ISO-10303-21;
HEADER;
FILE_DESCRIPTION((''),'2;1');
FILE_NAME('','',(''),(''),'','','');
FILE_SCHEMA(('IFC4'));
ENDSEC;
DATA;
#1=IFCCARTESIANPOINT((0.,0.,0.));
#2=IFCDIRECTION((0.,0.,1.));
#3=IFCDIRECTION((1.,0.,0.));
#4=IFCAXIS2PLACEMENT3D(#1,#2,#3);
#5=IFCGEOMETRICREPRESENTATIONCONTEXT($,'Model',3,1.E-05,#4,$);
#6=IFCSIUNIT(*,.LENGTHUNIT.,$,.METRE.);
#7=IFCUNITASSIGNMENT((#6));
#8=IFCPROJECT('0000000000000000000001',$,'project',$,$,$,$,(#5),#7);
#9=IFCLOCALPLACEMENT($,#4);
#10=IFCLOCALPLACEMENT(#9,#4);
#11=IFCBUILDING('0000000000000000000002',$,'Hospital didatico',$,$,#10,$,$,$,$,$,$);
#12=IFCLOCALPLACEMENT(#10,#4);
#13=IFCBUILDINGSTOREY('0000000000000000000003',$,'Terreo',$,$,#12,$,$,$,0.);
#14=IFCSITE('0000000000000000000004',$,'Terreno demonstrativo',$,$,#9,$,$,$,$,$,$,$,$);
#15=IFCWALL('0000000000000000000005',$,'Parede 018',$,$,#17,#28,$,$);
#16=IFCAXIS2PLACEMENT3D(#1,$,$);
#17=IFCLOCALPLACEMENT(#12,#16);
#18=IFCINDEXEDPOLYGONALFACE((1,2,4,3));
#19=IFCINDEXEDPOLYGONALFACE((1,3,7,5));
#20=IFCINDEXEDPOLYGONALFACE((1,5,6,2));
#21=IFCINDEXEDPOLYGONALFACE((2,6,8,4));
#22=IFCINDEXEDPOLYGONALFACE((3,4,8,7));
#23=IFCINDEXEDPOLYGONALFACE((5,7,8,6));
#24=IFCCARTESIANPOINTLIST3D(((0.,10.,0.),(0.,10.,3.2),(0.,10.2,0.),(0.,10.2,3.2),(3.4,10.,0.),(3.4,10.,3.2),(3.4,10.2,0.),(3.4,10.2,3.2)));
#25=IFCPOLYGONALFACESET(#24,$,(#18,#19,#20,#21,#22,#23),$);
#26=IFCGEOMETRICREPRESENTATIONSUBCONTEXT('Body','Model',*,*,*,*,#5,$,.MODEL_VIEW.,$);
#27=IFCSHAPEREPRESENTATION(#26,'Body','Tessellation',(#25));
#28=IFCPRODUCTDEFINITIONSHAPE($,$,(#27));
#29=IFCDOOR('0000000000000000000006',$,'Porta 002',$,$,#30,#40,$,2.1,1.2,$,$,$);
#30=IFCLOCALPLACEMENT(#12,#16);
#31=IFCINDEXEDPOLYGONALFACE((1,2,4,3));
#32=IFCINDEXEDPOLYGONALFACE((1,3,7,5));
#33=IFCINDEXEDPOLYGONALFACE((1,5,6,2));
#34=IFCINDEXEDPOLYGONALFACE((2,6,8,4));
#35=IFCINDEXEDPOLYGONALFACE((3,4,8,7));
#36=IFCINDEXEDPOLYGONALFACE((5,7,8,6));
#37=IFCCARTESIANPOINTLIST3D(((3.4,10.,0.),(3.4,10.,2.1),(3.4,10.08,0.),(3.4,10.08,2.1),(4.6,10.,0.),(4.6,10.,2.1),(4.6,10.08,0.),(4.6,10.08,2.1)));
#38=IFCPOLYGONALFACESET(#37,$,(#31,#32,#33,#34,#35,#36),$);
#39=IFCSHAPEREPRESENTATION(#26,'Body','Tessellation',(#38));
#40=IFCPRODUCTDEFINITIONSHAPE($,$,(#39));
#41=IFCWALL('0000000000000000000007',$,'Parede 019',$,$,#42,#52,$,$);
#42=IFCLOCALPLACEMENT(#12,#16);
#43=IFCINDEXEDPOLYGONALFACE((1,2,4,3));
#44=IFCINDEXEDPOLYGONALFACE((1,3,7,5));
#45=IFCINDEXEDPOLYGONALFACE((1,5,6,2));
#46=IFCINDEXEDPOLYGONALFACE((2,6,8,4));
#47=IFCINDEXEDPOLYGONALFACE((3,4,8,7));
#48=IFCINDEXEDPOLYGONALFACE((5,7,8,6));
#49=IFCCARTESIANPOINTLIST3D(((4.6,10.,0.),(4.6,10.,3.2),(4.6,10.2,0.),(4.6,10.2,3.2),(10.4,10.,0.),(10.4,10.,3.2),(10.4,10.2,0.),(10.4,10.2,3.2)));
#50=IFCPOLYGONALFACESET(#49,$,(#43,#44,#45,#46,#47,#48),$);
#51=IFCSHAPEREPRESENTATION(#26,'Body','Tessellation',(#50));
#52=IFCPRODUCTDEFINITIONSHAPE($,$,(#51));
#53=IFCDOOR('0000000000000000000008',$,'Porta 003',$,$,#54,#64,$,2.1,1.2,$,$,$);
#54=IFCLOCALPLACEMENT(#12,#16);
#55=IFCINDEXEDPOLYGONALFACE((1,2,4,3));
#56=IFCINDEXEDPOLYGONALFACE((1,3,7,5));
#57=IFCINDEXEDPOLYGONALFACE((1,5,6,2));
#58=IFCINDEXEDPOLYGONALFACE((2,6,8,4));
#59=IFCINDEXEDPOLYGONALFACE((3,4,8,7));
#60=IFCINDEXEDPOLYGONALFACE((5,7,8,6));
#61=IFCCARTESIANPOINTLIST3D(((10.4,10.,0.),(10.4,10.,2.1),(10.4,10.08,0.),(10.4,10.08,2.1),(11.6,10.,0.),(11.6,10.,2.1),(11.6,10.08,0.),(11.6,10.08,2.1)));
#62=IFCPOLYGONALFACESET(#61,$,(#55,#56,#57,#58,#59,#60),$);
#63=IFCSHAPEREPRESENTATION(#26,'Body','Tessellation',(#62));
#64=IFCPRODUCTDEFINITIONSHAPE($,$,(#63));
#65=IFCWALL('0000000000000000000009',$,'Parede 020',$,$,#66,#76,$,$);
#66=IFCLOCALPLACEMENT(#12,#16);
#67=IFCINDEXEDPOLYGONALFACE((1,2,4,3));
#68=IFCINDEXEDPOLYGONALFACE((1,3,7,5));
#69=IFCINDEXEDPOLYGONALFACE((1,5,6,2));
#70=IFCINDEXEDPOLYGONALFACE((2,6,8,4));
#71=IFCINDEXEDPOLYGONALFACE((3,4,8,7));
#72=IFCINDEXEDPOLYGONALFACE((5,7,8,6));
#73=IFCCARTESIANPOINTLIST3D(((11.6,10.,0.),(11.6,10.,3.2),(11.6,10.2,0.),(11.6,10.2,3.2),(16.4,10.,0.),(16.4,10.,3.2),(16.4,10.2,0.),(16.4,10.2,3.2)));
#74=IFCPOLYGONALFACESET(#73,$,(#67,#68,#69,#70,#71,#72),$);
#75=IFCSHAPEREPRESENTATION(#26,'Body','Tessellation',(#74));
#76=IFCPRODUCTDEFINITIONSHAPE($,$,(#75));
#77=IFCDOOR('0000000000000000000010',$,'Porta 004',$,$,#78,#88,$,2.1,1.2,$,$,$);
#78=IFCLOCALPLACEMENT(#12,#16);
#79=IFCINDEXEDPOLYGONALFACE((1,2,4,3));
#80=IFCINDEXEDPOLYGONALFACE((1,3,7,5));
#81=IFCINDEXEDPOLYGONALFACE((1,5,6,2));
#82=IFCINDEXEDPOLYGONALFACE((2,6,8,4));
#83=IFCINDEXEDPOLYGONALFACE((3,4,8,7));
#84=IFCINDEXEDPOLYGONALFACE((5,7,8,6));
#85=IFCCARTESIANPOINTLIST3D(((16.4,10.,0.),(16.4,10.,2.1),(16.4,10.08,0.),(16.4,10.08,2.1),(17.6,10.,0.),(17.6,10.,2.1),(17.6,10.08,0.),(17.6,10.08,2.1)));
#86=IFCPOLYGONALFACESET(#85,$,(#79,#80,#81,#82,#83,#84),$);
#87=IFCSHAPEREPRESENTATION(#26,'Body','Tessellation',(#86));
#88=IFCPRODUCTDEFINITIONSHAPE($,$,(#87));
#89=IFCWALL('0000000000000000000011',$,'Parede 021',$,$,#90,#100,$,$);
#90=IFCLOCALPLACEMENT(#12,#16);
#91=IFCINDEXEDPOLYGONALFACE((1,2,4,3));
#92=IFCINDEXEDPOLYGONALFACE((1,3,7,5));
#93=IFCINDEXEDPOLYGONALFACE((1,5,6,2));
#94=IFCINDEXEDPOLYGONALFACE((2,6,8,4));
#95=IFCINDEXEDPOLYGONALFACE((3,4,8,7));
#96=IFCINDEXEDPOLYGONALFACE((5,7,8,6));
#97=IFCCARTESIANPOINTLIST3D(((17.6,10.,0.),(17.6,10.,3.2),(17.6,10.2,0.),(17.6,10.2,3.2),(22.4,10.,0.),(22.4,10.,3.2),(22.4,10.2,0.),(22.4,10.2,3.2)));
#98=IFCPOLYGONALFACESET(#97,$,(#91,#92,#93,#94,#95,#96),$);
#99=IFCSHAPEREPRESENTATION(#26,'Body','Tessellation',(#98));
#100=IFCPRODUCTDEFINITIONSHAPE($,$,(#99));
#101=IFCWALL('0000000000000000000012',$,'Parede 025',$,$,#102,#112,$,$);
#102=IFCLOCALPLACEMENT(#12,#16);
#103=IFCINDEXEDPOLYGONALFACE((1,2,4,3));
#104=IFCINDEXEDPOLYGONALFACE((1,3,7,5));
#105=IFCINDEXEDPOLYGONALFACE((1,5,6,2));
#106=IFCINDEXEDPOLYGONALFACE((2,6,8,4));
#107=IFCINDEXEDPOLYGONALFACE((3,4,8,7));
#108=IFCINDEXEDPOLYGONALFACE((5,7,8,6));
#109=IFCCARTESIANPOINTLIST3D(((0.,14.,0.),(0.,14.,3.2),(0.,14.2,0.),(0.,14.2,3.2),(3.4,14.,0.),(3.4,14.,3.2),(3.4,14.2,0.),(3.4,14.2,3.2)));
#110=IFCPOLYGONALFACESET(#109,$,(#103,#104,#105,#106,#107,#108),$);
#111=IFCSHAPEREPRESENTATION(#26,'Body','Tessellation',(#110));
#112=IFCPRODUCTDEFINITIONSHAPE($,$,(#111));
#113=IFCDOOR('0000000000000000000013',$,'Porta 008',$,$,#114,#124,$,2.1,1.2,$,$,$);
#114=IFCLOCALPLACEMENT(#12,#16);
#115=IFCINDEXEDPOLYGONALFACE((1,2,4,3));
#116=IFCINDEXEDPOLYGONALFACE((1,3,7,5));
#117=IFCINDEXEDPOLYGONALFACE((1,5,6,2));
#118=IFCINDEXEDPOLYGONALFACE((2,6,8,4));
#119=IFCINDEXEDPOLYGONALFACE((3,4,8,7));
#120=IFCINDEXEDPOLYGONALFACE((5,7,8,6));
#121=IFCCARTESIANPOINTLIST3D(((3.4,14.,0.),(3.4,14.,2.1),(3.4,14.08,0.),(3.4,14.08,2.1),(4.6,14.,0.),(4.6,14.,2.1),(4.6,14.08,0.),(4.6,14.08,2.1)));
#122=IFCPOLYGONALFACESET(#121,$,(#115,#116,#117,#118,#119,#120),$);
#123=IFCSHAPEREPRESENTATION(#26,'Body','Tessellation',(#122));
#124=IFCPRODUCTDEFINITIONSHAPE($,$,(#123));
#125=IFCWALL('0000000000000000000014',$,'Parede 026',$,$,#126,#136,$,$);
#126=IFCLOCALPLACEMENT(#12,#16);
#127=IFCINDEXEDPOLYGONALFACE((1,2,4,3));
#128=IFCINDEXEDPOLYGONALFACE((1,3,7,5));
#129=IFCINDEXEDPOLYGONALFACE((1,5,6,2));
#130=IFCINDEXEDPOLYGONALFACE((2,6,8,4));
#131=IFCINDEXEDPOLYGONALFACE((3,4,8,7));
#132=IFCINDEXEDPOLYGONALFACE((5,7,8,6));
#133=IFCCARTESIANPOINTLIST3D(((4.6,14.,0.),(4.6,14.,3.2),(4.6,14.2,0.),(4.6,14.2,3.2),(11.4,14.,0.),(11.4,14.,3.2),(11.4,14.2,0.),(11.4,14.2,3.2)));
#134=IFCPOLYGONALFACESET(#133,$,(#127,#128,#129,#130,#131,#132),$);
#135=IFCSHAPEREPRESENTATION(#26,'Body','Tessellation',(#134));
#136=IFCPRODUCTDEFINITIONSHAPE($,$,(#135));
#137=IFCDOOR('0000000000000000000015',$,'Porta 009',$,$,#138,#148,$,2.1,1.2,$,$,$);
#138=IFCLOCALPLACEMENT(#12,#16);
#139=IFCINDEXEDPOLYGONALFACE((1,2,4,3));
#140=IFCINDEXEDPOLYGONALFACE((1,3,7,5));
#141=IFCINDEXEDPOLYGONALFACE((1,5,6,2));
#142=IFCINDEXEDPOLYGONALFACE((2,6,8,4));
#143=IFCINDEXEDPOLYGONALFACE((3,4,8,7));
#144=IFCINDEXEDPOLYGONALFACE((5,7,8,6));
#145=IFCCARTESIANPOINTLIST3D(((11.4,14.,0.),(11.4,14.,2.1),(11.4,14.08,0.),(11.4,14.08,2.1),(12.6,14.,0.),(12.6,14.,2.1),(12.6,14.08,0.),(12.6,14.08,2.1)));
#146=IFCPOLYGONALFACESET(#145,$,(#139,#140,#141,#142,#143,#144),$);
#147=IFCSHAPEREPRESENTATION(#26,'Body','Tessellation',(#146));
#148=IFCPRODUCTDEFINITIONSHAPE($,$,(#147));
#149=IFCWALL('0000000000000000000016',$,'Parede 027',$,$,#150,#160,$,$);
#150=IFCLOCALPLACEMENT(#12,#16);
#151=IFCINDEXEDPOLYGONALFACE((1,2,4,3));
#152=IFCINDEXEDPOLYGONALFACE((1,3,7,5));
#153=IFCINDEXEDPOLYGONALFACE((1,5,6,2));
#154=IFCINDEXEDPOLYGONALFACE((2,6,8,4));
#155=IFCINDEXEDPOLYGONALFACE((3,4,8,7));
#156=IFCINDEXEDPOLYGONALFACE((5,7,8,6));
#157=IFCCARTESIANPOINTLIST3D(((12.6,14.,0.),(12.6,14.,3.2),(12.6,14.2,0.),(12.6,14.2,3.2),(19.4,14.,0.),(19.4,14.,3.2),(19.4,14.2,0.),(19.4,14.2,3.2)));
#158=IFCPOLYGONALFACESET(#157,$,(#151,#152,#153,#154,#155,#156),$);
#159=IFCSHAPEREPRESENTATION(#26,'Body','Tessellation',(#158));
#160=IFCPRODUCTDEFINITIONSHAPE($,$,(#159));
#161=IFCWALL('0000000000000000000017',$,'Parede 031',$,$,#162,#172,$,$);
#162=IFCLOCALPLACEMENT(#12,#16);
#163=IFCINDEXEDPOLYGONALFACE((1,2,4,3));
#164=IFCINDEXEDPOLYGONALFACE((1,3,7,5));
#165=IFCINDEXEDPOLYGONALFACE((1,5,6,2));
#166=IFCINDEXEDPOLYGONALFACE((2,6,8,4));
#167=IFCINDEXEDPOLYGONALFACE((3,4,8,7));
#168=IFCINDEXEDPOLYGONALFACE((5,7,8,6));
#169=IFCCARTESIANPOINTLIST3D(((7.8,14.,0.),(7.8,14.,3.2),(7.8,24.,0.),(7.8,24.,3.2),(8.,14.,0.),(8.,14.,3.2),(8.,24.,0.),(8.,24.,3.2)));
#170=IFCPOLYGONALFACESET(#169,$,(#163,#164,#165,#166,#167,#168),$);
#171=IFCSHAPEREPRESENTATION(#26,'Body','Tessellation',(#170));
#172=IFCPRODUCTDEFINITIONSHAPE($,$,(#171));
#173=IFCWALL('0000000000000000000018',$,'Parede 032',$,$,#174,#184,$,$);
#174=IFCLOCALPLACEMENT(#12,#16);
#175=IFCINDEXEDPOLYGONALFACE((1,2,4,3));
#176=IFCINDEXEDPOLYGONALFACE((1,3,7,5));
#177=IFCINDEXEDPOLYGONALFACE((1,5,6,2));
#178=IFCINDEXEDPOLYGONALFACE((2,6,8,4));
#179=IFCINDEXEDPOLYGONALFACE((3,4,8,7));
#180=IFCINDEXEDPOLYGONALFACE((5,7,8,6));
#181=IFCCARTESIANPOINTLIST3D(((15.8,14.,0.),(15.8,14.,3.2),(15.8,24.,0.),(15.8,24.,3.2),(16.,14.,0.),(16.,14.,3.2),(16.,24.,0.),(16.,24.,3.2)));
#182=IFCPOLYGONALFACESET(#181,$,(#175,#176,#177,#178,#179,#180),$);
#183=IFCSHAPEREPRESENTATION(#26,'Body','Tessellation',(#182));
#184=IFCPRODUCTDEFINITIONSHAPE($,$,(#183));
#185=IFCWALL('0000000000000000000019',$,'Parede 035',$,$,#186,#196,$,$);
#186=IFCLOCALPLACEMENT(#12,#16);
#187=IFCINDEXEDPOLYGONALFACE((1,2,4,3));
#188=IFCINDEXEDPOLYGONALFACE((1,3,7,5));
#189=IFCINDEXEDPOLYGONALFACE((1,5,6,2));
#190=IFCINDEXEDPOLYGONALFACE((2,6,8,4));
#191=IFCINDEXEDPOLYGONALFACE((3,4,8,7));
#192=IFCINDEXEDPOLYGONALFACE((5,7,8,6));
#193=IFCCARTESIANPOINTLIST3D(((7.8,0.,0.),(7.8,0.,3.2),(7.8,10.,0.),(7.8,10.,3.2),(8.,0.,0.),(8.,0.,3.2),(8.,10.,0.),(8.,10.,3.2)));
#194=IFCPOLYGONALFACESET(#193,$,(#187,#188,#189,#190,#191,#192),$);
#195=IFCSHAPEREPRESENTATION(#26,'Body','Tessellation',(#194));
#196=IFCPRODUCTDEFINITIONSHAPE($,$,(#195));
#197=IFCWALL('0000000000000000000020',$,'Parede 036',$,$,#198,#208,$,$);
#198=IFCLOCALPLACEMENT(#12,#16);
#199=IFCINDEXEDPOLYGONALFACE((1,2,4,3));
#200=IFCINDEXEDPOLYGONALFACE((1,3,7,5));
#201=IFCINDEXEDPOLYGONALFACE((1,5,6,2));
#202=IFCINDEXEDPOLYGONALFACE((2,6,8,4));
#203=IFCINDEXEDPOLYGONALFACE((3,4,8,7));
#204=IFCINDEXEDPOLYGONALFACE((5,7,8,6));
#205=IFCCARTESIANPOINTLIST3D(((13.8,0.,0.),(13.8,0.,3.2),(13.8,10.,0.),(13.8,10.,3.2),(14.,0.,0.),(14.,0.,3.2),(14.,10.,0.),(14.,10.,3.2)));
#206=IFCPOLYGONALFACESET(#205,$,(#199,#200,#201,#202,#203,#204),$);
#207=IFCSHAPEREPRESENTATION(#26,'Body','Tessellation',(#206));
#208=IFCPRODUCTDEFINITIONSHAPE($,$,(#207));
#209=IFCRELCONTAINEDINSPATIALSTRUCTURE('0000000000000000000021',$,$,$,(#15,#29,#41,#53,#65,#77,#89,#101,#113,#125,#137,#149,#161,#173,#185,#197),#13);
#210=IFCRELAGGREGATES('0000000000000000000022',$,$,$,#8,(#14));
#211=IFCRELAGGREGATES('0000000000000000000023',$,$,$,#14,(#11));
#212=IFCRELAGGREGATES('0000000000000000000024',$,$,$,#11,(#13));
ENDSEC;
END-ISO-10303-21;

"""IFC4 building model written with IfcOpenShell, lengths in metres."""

from ifc_helpers import new_model, si_unit, frame, origin_with_axes, place, context, subcontext, project, spatial, indexed_curve, outline, extrude, element, save


model = new_model("IFC4")

# Units and contexts
model_context = context("Model", 3, precision=1e-05, world=origin_with_axes())
body_context = subcontext(model_context, "Body", "Model", "MODEL_VIEW")
ifc_project = project(units=[si_unit("LENGTHUNIT", "METRE")], contexts=[model_context])

# Site, building, storey
site_placement = place(None, origin_with_axes())
site = spatial("IfcSite", under=ifc_project, at=site_placement, Name="Terreno demonstrativo")
building_placement = place(site_placement, origin_with_axes())
building = spatial("IfcBuilding", under=site, at=building_placement, Name="Hospital didatico")
storey_placement = place(building_placement, origin_with_axes())
storey = spatial("IfcBuildingStorey", under=building, at=storey_placement, Name="Terreo", Elevation=0.0)

# Wall
wall_1_placement = place(storey_placement, frame((0.0, 10.0, 0.0), z_axis=(0.0, 0.0, 1.0), x_axis=(1.0, 0.0, 0.0)))
element("IfcWall", 1, at=wall_1_placement, inside=storey, Name="Parede 018", context=body_context, shape_type="SweptSolid", body=[
    extrude(outline(indexed_curve([(0.0, 0.0), (0.0, 0.2), (3.4, 0.2), (3.4, 0.0), (0.0, 0.0)], self_intersect=False)), origin_with_axes(), (0.0, 0.0, 1.0), 3.2),
])

# Door
door_1_placement = place(storey_placement, frame((3.4, 10.0, 0.0), z_axis=(0.0, 0.0, 1.0), x_axis=(1.0, 0.0, 0.0)))
element("IfcDoor", 2, at=door_1_placement, inside=storey, Name="Porta 002", OverallHeight=2.1, OverallWidth=1.2, context=body_context, shape_type="SweptSolid", body=[
    extrude(outline(indexed_curve([(0.0, 0.0), (0.0, 0.08), (1.2, 0.08), (1.2, 0.0), (0.0, 0.0)], self_intersect=False)), origin_with_axes(), (0.0, 0.0, 1.0), 2.1),
])

# Wall
wall_2_placement = place(storey_placement, frame((4.6, 10.0, 0.0), z_axis=(0.0, 0.0, 1.0), x_axis=(1.0, 0.0, 0.0)))
element("IfcWall", 3, at=wall_2_placement, inside=storey, Name="Parede 019", context=body_context, shape_type="SweptSolid", body=[
    extrude(outline(indexed_curve([(0.0, 0.0), (0.0, 0.2), (5.8, 0.2), (5.8, 0.0), (0.0, 0.0)], self_intersect=False)), origin_with_axes(), (0.0, 0.0, 1.0), 3.2),
])

# Door
door_2_placement = place(storey_placement, frame((10.4, 10.0, 0.0), z_axis=(0.0, 0.0, 1.0), x_axis=(1.0, 0.0, 0.0)))
element("IfcDoor", 4, at=door_2_placement, inside=storey, Name="Porta 003", OverallHeight=2.1, OverallWidth=1.2, context=body_context, shape_type="SweptSolid", body=[
    extrude(outline(indexed_curve([(0.0, 0.0), (0.0, 0.08), (1.2, 0.08), (1.2, 0.0), (0.0, 0.0)], self_intersect=False)), origin_with_axes(), (0.0, 0.0, 1.0), 2.1),
])

# Wall
wall_3_placement = place(storey_placement, frame((11.6, 10.0, 0.0), z_axis=(0.0, 0.0, 1.0), x_axis=(1.0, 0.0, 0.0)))
element("IfcWall", 5, at=wall_3_placement, inside=storey, Name="Parede 020", context=body_context, shape_type="SweptSolid", body=[
    extrude(outline(indexed_curve([(0.0, 0.0), (0.0, 0.2), (4.8, 0.2), (4.8, 0.0), (0.0, 0.0)], self_intersect=False)), origin_with_axes(), (0.0, 0.0, 1.0), 3.2),
])

# Door
door_3_placement = place(storey_placement, frame((16.4, 10.0, 0.0), z_axis=(0.0, 0.0, 1.0), x_axis=(1.0, 0.0, 0.0)))
element("IfcDoor", 6, at=door_3_placement, inside=storey, Name="Porta 004", OverallHeight=2.1, OverallWidth=1.2, context=body_context, shape_type="SweptSolid", body=[
    extrude(outline(indexed_curve([(0.0, 0.0), (0.0, 0.08), (1.2, 0.08), (1.2, 0.0), (0.0, 0.0)], self_intersect=False)), origin_with_axes(), (0.0, 0.0, 1.0), 2.1),
])

# Walls
wall_4_placement = place(storey_placement, frame((17.6, 10.0, 0.0), z_axis=(0.0, 0.0, 1.0), x_axis=(1.0, 0.0, 0.0)))
element("IfcWall", 7, at=wall_4_placement, inside=storey, Name="Parede 021", context=body_context, shape_type="SweptSolid", body=[
    extrude(outline(indexed_curve([(0.0, 0.0), (0.0, 0.2), (4.8, 0.2), (4.8, 0.0), (0.0, 0.0)], self_intersect=False)), origin_with_axes(), (0.0, 0.0, 1.0), 3.2),
])
wall_5_placement = place(storey_placement, frame((0.0, 14.0, 0.0), z_axis=(0.0, 0.0, 1.0), x_axis=(1.0, 0.0, 0.0)))
element("IfcWall", 8, at=wall_5_placement, inside=storey, Name="Parede 025", context=body_context, shape_type="SweptSolid", body=[
    extrude(outline(indexed_curve([(0.0, 0.0), (0.0, 0.2), (3.4, 0.2), (3.4, 0.0), (0.0, 0.0)], self_intersect=False)), origin_with_axes(), (0.0, 0.0, 1.0), 3.2),
])

# Door
door_4_placement = place(storey_placement, frame((3.4, 14.0, 0.0), z_axis=(0.0, 0.0, 1.0), x_axis=(1.0, 0.0, 0.0)))
element("IfcDoor", 9, at=door_4_placement, inside=storey, Name="Porta 008", OverallHeight=2.1, OverallWidth=1.2, context=body_context, shape_type="SweptSolid", body=[
    extrude(outline(indexed_curve([(0.0, 0.0), (0.0, 0.08), (1.2, 0.08), (1.2, 0.0), (0.0, 0.0)], self_intersect=False)), origin_with_axes(), (0.0, 0.0, 1.0), 2.1),
])

# Wall
wall_6_placement = place(storey_placement, frame((4.6, 14.0, 0.0), z_axis=(0.0, 0.0, 1.0), x_axis=(1.0, 0.0, 0.0)))
element("IfcWall", 10, at=wall_6_placement, inside=storey, Name="Parede 026", context=body_context, shape_type="SweptSolid", body=[
    extrude(outline(indexed_curve([(0.0, 0.0), (0.0, 0.2), (6.8, 0.2), (6.8, 0.0), (0.0, 0.0)], self_intersect=False)), origin_with_axes(), (0.0, 0.0, 1.0), 3.2),
])

# Door
door_5_placement = place(storey_placement, frame((11.4, 14.0, 0.0), z_axis=(0.0, 0.0, 1.0), x_axis=(1.0, 0.0, 0.0)))
element("IfcDoor", 11, at=door_5_placement, inside=storey, Name="Porta 009", OverallHeight=2.1, OverallWidth=1.2, context=body_context, shape_type="SweptSolid", body=[
    extrude(outline(indexed_curve([(0.0, 0.0), (0.0, 0.08), (1.2, 0.08), (1.2, 0.0), (0.0, 0.0)], self_intersect=False)), origin_with_axes(), (0.0, 0.0, 1.0), 2.1),
])

# Walls
wall_7_placement = place(storey_placement, frame((12.6, 14.0, 0.0), z_axis=(0.0, 0.0, 1.0), x_axis=(1.0, 0.0, 0.0)))
element("IfcWall", 12, at=wall_7_placement, inside=storey, Name="Parede 027", context=body_context, shape_type="SweptSolid", body=[
    extrude(outline(indexed_curve([(0.0, 0.0), (0.0, 0.2), (6.8, 0.2), (6.8, 0.0), (0.0, 0.0)], self_intersect=False)), origin_with_axes(), (0.0, 0.0, 1.0), 3.2),
])
for number, where, z_axis, x_axis, name in (
    (13, (8.0, 14.0, 0.0), (0.0, 0.0, 1.0), (0.0, 1.0, 0.0), "Parede 031"),
    (14, (16.0, 14.0, 0.0), (0.0, 0.0, 1.0), (0.0, 1.0, 0.0), "Parede 032"),
    (15, (8.0, 0.0, 0.0), (0.0, 0.0, 1.0), (0.0, 1.0, 0.0), "Parede 035"),
    (16, (14.0, 0.0, 0.0), (0.0, 0.0, 1.0), (0.0, 1.0, 0.0), "Parede 036"),
):
    element("IfcWall", number, at=place(storey_placement, frame(where, z_axis=z_axis, x_axis=x_axis)), inside=storey, Name=name, context=body_context, shape_type="SweptSolid", body=[
        extrude(outline(indexed_curve([(0.0, 0.0), (0.0, 0.2), (10.0, 0.2), (10.0, 0.0), (0.0, 0.0)], self_intersect=False)), origin_with_axes(), (0.0, 0.0, 1.0), 3.2),
    ])

save(model, "model.ifc")
